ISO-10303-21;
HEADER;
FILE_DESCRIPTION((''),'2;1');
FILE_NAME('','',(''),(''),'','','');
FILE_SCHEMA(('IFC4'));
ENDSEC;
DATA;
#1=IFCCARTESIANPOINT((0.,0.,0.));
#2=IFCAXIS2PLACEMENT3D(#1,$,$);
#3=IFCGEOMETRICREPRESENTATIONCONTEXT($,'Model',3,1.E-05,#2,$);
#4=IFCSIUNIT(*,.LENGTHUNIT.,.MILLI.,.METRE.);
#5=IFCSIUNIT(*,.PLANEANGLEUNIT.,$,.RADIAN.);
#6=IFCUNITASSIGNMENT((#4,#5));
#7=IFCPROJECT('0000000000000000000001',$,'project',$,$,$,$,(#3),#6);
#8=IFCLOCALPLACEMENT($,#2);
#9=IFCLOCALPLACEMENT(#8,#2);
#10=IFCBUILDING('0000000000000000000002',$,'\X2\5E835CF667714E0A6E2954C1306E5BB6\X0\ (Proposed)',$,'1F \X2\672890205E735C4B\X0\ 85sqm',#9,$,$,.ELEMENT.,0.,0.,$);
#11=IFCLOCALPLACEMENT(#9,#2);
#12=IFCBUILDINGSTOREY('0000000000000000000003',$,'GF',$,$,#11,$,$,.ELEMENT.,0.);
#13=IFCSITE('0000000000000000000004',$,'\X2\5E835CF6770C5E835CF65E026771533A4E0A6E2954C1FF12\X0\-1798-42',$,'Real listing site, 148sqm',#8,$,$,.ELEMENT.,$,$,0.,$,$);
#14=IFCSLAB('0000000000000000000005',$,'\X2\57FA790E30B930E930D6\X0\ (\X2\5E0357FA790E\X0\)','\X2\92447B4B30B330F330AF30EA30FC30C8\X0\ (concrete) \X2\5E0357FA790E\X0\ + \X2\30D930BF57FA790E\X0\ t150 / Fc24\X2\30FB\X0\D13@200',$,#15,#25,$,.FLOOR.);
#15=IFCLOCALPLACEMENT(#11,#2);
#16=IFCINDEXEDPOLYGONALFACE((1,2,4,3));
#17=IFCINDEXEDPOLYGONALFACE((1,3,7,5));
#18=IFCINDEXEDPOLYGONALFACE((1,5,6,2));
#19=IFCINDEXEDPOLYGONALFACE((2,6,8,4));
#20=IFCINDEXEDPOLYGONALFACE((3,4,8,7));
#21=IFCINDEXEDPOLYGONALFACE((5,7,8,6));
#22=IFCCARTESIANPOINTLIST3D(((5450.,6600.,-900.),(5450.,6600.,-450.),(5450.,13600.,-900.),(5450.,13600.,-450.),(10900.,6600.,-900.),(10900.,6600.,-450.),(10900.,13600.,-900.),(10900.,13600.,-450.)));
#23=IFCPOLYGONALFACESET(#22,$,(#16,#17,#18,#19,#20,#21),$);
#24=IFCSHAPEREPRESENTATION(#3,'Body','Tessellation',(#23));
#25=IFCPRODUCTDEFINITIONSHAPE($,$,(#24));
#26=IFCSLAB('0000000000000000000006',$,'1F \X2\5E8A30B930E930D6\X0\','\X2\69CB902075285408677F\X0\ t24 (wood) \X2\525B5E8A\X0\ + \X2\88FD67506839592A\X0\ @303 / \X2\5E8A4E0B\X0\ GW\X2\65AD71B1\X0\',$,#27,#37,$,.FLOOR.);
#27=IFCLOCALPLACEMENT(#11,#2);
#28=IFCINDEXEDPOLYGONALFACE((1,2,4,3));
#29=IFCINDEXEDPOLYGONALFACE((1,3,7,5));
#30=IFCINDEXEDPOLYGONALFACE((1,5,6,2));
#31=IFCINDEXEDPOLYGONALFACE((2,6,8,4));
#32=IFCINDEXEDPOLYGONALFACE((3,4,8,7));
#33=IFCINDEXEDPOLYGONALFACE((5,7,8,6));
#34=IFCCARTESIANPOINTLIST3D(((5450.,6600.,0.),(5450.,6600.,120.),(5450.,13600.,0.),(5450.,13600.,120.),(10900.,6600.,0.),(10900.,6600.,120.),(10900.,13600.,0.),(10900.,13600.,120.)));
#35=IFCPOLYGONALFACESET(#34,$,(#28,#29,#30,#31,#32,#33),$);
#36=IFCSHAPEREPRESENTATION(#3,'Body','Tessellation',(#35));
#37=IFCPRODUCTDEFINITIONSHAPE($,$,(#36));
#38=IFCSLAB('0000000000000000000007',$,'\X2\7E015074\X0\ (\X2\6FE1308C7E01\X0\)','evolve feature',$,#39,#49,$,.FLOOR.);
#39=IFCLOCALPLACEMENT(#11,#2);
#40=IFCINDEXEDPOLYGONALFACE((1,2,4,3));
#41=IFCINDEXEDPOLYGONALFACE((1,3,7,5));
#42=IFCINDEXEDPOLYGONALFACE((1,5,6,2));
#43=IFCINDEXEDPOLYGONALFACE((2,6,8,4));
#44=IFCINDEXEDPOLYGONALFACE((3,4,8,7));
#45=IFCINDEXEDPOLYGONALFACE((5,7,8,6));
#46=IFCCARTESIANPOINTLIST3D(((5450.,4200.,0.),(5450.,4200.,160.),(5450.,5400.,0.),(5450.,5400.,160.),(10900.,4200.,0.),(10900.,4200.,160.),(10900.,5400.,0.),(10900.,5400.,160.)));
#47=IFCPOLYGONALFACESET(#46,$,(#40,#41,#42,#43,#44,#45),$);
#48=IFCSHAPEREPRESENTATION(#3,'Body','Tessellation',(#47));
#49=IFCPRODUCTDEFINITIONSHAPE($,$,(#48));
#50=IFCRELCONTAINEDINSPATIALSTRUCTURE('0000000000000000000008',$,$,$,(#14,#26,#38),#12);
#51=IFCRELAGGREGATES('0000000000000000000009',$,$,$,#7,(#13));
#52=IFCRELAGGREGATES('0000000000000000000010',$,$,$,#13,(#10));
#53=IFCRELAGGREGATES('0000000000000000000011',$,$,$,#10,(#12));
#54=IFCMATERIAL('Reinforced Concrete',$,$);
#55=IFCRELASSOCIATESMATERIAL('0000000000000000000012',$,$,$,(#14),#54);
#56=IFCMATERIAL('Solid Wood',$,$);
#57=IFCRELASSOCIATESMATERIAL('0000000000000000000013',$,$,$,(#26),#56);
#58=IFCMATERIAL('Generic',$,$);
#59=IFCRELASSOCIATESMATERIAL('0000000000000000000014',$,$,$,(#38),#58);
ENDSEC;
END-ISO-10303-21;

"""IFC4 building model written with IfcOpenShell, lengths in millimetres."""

from ifc_helpers import new_model, si_unit, frame, frame_2d, origin, place, context, project, spatial, rectangle, extrude, material, element, save


model = new_model("IFC4")

# Units and contexts
model_context = context("Model", 3, precision=1e-05, world=origin())
ifc_project = project(units=[si_unit("LENGTHUNIT", "METRE", prefix="MILLI"), si_unit("PLANEANGLEUNIT", "RADIAN")], contexts=[model_context])

# Site, building, storey
site_placement = place(None, origin())
site = spatial("IfcSite", under=ifc_project, at=site_placement, Name="広島県広島市東区上温品２-1798-42", ObjectType="Real listing site, 148sqm", CompositionType="ELEMENT", RefElevation=0.0)
building_placement = place(site_placement, origin())
building = spatial("IfcBuilding", under=site, at=building_placement, Name="広島東上温品の家 (Proposed)", ObjectType="1F 木造平屋 85sqm", CompositionType="ELEMENT", ElevationOfRefHeight=0.0, ElevationOfTerrain=0.0)
storey_placement = place(building_placement, origin())
storey = spatial("IfcBuildingStorey", under=building, at=storey_placement, Name="GF", CompositionType="ELEMENT", Elevation=0.0)

# Slabs
ifc_material_1 = material(Name="Reinforced Concrete")
slab_1_placement = place(storey_placement, frame((2725.0, 3300.0, -450.0)))
element("IfcSlab", 1, at=slab_1_placement, inside=storey, material=ifc_material_1, Name="基礎スラブ (布基礎)", Description="鉄筋コンクリート (concrete) 布基礎 + ベタ基礎 t150 / Fc24・D13@200", PredefinedType="FLOOR", context=model_context, shape_type="SweptSolid", body=[
    extrude(rectangle(XDim=5450.0, YDim=7000.0, at=frame_2d((2725.0, 3500.0))), frame((2725.0, 3300.0, -450.0)), (0.0, 0.0, 1.0), 450.0),
])
ifc_material_2 = material(Name="Solid Wood")
slab_2_placement = place(storey_placement, frame((2725.0, 3300.0, 0.0)))
element("IfcSlab", 2, at=slab_2_placement, inside=storey, material=ifc_material_2, Name="1F 床スラブ", Description="構造用合板 t24 (wood) 剛床 + 製材根太 @303 / 床下 GW断熱", PredefinedType="FLOOR", context=model_context, shape_type="SweptSolid", body=[
    extrude(rectangle(XDim=5450.0, YDim=7000.0, at=frame_2d((2725.0, 3500.0))), frame((2725.0, 3300.0, 0.0)), (0.0, 0.0, 1.0), 120.0),
])
ifc_material_3 = material(Name="Generic")
slab_3_placement = place(storey_placement, frame((2725.0, 2100.0, 0.0)))
element("IfcSlab", 3, at=slab_3_placement, inside=storey, material=ifc_material_3, Name="縁側 (濡れ縁)", Description="evolve feature", PredefinedType="FLOOR", context=model_context, shape_type="SweptSolid", body=[
    extrude(rectangle(XDim=5450.0, YDim=1200.0, at=frame_2d((2725.0, 600.0))), frame((2725.0, 2100.0, 0.0)), (0.0, 0.0, 1.0), 160.0),
])

save(model, "model.ifc")
